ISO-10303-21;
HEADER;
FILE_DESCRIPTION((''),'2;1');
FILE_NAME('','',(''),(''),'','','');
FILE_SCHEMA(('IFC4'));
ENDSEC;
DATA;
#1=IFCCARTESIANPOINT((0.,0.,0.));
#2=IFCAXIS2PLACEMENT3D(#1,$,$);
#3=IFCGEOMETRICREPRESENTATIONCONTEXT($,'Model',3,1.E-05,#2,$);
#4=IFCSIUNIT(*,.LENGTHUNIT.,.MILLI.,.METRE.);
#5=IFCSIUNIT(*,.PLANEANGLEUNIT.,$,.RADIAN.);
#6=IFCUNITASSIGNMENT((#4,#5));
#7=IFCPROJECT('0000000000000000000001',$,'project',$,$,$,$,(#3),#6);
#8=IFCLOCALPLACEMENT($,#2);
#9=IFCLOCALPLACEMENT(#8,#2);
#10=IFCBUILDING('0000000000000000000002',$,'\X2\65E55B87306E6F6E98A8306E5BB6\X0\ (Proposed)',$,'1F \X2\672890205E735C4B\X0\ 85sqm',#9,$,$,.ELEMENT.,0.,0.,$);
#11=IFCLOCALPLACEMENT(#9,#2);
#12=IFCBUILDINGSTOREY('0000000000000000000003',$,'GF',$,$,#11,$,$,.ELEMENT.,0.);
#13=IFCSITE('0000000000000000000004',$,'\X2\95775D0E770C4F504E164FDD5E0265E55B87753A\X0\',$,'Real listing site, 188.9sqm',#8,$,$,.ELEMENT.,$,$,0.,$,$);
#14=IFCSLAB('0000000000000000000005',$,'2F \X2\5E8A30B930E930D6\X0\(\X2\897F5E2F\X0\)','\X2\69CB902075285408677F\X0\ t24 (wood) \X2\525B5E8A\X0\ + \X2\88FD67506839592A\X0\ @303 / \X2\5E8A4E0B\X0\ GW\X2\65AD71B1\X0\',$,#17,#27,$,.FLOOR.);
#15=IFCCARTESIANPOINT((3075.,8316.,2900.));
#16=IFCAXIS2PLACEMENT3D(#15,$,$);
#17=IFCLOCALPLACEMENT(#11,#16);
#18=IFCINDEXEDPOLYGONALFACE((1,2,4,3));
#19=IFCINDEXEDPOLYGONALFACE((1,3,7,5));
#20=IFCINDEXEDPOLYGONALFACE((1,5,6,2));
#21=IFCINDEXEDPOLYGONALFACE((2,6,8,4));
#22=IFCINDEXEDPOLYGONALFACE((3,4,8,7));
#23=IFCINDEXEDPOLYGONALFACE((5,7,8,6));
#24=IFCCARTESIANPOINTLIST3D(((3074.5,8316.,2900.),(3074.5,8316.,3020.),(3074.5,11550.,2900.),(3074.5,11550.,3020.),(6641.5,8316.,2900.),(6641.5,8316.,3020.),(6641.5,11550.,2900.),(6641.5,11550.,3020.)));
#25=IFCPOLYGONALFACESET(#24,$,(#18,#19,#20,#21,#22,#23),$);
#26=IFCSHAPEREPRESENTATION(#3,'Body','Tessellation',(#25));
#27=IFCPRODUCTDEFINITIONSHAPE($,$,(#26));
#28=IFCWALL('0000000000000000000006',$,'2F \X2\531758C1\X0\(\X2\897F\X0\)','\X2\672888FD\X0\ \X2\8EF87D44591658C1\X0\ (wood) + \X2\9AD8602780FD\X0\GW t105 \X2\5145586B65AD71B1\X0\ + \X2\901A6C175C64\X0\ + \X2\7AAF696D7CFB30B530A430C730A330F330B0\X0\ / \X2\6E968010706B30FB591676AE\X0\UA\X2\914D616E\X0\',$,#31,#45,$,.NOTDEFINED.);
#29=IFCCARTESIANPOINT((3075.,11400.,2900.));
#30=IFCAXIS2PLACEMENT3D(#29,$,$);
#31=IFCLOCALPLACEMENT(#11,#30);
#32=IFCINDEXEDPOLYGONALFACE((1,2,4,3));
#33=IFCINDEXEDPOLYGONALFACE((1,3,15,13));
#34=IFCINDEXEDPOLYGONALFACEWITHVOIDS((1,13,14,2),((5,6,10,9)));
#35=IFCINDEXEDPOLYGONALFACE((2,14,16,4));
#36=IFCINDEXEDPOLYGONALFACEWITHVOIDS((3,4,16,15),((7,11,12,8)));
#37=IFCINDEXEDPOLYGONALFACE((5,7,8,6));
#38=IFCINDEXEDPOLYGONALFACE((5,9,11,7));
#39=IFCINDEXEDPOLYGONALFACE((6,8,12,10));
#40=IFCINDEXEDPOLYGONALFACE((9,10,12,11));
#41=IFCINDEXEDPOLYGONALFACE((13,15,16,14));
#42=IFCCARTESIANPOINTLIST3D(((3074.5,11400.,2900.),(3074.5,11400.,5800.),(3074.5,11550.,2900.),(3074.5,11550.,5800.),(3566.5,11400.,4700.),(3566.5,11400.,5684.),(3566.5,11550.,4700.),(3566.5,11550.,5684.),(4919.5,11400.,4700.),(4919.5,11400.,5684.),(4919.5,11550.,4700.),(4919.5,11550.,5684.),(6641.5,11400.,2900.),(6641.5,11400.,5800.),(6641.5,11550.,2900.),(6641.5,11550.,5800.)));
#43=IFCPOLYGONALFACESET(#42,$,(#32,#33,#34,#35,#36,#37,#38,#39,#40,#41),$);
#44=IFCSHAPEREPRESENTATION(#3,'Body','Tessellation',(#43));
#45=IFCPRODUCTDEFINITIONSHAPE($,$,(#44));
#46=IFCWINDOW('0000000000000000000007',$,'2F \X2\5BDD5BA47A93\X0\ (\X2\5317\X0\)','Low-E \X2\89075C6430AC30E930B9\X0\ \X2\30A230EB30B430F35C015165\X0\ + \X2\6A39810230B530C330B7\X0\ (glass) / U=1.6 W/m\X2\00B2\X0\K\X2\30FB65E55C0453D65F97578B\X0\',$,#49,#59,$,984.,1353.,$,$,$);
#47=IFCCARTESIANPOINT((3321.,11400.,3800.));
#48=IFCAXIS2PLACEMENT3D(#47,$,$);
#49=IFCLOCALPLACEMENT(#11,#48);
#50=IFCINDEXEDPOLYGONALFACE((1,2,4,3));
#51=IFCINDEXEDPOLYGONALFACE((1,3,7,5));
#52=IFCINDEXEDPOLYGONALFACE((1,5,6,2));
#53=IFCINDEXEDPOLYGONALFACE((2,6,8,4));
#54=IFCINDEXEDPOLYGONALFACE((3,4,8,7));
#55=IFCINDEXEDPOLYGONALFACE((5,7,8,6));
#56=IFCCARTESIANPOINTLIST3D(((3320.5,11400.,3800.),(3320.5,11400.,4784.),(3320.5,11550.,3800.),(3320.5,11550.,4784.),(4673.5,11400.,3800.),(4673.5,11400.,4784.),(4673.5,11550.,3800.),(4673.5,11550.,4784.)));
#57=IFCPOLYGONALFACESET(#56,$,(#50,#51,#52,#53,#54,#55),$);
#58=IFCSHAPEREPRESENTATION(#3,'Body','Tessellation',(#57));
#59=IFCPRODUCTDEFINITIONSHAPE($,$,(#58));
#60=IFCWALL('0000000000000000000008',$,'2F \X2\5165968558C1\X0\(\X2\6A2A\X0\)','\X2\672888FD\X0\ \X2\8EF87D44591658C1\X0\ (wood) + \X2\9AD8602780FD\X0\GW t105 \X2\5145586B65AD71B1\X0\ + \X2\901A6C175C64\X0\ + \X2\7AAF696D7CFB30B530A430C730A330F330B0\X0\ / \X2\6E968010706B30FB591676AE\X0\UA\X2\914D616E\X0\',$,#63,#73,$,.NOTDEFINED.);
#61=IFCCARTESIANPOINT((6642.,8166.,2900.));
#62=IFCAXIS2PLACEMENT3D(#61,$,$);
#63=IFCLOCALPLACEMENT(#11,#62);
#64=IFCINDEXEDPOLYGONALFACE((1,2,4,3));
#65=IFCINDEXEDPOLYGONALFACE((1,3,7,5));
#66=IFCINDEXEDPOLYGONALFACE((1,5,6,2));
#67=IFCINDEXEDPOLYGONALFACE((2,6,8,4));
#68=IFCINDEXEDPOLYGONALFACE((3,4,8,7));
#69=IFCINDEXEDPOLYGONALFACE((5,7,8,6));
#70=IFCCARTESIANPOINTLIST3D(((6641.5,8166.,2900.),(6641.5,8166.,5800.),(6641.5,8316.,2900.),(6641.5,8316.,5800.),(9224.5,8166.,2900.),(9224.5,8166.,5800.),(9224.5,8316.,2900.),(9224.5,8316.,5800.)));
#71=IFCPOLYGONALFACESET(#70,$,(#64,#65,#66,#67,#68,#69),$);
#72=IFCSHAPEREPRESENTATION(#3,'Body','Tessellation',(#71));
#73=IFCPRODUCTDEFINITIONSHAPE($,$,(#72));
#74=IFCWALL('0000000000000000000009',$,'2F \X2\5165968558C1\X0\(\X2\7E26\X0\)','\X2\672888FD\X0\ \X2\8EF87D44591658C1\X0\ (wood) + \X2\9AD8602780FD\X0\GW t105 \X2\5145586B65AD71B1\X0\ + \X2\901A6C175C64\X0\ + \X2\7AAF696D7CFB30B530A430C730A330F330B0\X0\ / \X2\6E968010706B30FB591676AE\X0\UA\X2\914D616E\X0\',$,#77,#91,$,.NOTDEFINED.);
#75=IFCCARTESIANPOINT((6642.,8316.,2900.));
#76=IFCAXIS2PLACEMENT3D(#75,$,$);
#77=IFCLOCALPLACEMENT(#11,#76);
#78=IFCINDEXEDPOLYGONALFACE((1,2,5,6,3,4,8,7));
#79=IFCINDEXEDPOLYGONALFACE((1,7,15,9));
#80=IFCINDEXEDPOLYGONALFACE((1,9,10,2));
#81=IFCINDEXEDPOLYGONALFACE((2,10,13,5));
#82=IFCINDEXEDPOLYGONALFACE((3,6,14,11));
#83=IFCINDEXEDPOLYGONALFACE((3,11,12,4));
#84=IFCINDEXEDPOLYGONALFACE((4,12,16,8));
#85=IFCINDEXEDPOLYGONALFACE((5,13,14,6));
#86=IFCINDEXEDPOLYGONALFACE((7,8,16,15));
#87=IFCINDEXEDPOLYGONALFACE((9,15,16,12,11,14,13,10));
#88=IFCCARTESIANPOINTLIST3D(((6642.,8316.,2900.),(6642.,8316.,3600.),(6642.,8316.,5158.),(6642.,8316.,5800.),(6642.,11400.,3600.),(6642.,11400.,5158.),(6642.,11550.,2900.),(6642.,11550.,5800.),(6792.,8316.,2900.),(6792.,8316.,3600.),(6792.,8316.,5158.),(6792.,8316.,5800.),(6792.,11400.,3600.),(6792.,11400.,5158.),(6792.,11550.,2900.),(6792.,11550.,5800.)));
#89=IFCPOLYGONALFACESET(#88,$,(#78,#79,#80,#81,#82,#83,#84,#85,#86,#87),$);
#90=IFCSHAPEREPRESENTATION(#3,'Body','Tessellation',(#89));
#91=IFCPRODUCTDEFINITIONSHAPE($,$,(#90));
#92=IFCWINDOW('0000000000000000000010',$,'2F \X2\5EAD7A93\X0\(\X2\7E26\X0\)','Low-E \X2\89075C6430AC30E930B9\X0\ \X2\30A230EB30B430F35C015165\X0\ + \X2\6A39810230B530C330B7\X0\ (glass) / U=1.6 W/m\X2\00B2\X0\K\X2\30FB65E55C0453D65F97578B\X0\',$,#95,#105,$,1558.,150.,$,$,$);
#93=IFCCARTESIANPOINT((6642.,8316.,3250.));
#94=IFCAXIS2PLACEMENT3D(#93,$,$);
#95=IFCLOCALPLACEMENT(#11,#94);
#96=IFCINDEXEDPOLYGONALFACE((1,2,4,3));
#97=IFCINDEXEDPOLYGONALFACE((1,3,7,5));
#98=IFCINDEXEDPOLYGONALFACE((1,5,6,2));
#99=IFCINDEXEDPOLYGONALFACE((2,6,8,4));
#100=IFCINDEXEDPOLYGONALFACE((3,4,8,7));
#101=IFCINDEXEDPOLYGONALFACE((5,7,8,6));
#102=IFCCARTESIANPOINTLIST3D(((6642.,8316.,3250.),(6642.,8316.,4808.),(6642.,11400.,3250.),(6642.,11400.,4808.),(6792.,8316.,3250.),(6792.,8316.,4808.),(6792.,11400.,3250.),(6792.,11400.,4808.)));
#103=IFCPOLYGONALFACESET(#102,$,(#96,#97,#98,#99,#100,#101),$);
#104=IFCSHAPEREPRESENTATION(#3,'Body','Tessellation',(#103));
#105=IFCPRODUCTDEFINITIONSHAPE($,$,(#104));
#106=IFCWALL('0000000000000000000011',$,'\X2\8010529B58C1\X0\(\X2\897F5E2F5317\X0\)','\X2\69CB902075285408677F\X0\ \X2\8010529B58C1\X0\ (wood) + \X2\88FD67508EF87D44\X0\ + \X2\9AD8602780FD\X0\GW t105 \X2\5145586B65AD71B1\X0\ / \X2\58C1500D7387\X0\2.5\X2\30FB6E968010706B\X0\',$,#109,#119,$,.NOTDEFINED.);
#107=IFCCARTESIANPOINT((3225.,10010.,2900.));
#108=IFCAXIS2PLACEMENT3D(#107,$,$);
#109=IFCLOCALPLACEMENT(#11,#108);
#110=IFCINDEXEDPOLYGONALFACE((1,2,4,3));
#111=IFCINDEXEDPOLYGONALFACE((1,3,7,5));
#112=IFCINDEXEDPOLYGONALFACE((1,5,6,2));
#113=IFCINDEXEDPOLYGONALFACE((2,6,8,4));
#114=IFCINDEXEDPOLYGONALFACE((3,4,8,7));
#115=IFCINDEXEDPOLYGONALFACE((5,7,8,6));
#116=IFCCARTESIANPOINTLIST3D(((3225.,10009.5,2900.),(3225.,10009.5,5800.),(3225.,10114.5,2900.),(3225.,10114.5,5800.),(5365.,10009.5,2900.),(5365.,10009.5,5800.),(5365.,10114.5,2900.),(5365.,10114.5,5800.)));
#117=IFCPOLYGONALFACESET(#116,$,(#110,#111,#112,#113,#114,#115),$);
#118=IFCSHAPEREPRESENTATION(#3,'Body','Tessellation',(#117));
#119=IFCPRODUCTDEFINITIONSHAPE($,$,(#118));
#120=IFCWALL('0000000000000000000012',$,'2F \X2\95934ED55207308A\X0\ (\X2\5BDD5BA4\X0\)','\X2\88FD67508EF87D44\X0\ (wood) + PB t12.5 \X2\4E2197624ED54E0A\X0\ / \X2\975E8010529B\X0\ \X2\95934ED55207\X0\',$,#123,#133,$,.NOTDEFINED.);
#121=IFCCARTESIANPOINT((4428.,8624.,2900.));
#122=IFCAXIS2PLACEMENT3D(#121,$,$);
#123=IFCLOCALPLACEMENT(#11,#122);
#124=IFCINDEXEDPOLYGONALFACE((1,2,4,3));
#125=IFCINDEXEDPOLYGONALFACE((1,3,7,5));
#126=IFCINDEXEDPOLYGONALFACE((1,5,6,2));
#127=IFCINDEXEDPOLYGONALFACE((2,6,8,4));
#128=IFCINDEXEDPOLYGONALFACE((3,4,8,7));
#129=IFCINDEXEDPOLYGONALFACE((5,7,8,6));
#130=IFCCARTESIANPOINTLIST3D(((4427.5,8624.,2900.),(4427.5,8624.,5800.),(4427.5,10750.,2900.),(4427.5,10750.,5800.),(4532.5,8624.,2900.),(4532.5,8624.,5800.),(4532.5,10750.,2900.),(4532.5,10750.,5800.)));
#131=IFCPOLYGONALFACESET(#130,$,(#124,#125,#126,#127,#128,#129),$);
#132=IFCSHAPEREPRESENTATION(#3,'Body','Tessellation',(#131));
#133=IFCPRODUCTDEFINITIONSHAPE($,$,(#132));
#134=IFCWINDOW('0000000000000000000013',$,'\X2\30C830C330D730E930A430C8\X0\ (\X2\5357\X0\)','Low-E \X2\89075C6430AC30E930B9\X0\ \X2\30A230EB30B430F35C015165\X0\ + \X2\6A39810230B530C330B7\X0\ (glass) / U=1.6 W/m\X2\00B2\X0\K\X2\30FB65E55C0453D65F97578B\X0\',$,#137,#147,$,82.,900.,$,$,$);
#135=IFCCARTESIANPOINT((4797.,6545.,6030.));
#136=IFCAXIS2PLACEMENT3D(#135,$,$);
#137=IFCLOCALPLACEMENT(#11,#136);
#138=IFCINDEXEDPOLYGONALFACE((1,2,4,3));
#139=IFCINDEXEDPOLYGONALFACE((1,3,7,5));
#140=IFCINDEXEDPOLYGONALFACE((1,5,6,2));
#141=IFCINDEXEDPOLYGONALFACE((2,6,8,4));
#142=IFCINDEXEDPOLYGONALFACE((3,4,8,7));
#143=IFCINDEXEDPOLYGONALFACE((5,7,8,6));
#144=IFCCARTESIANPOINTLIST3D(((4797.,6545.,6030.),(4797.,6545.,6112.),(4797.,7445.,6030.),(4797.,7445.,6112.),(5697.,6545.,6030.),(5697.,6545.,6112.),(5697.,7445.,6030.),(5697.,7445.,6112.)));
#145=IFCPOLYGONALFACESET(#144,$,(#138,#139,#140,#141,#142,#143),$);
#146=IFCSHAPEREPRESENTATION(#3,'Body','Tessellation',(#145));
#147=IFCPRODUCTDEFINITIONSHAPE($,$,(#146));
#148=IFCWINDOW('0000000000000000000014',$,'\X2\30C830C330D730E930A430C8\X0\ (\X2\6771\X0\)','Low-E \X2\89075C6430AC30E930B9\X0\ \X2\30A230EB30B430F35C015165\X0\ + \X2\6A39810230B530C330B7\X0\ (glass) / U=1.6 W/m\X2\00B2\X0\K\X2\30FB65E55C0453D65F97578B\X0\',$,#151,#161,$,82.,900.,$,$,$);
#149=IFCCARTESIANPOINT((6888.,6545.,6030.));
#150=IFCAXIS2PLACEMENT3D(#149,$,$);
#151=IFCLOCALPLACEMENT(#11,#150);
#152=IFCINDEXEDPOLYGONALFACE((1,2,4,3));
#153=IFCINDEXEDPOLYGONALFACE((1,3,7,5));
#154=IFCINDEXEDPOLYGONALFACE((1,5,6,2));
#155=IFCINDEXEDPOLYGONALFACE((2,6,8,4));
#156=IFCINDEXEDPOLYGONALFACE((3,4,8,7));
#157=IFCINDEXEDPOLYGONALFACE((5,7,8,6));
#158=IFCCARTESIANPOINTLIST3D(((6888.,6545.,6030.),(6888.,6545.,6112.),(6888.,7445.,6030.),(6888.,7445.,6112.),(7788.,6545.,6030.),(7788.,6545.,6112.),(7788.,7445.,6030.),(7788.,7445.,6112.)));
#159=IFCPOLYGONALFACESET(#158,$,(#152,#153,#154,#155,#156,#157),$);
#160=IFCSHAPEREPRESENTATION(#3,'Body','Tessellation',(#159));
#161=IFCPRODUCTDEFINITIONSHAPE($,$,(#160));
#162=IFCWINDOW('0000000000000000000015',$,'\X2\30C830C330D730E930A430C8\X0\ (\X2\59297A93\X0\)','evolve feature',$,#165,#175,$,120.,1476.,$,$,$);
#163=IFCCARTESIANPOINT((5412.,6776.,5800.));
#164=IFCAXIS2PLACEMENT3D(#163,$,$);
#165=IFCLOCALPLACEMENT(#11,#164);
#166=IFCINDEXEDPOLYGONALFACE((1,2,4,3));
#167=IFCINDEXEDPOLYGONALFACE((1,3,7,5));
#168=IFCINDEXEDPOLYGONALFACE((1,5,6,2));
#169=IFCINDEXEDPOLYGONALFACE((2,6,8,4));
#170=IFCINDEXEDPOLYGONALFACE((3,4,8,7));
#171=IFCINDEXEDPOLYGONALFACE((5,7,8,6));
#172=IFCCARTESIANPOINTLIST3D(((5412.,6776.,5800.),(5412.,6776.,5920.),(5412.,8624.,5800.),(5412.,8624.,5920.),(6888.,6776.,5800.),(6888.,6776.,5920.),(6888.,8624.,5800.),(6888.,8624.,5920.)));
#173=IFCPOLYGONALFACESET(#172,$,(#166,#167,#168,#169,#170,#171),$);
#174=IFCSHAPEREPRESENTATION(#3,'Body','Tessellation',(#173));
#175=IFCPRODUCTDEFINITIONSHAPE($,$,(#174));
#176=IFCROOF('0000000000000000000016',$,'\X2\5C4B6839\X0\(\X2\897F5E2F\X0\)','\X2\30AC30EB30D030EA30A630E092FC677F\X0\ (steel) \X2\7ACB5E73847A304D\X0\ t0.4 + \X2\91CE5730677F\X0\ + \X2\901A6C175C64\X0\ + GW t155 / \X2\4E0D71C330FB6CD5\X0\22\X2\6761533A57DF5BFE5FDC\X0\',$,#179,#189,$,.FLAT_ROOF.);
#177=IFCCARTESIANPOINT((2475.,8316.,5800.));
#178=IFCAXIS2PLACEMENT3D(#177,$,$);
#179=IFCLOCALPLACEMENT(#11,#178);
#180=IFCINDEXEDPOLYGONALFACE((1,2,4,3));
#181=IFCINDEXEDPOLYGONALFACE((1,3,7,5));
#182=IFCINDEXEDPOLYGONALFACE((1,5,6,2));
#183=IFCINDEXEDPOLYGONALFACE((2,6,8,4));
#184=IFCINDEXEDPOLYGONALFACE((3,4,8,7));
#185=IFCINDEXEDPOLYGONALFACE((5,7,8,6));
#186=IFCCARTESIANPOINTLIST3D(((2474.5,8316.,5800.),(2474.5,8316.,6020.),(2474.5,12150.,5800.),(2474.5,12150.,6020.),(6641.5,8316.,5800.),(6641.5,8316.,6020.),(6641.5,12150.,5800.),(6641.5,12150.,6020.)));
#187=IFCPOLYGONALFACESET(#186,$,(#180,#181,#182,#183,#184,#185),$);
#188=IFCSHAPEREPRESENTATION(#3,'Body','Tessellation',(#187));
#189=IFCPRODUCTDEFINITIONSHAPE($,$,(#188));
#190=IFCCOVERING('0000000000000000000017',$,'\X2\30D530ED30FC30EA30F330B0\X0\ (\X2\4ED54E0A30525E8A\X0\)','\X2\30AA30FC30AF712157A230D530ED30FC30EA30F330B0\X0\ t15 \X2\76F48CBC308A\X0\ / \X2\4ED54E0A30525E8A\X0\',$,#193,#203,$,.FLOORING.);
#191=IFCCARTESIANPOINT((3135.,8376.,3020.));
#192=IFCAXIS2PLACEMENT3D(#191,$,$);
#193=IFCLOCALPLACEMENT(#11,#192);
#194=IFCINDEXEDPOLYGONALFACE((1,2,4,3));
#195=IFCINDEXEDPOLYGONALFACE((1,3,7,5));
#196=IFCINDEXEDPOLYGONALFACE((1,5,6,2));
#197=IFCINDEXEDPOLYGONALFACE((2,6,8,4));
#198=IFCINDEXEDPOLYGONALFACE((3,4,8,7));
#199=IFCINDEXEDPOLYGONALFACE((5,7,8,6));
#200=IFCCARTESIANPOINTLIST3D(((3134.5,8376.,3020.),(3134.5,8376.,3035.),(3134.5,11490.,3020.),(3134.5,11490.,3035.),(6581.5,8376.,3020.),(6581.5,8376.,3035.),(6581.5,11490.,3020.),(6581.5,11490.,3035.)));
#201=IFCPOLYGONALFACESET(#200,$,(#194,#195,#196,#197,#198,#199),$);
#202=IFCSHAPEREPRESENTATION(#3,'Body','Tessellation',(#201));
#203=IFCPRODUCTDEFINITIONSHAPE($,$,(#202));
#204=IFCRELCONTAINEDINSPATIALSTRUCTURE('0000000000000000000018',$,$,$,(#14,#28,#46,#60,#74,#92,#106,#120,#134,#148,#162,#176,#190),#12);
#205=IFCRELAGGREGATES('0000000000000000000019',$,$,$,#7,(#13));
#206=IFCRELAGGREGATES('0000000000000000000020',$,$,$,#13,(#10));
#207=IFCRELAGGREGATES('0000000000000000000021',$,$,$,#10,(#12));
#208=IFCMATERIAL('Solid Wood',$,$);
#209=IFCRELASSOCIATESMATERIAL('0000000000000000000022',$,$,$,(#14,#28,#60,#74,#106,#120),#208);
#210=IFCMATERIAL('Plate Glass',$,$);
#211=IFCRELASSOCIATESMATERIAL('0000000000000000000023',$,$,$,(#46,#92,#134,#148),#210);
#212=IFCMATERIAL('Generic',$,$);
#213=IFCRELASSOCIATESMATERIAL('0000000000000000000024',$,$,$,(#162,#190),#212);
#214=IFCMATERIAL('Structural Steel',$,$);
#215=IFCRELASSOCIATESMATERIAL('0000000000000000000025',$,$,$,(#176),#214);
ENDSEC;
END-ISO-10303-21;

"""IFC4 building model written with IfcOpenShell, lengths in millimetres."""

from ifc_helpers import new_model, si_unit, frame, frame_2d, origin, place, context, project, spatial, rectangle, extrude, material, element, fill, save


model = new_model("IFC4")

# Units and contexts
model_context = context("Model", 3, precision=1e-05, world=origin())
ifc_project = project(units=[si_unit("LENGTHUNIT", "METRE", prefix="MILLI"), si_unit("PLANEANGLEUNIT", "RADIAN")], contexts=[model_context])

# Site, building, storey
site_placement = place(None, origin())
site = spatial("IfcSite", under=ifc_project, at=site_placement, Name="長崎県佐世保市日宇町", ObjectType="Real listing site, 188.9sqm", CompositionType="ELEMENT", RefElevation=0.0)
building_placement = place(site_placement, origin())
building = spatial("IfcBuilding", under=site, at=building_placement, Name="日宇の潮風の家 (Proposed)", ObjectType="1F 木造平屋 85sqm", CompositionType="ELEMENT", ElevationOfRefHeight=0.0, ElevationOfTerrain=0.0)
storey_placement = place(building_placement, origin())
storey = spatial("IfcBuildingStorey", under=building, at=storey_placement, Name="GF", CompositionType="ELEMENT", Elevation=0.0)

# Slab
ifc_material_1 = material(Name="Solid Wood")
slab_placement = place(storey_placement, frame((3075.0, 8316.0, 2900.0)))
element("IfcSlab", 1, at=slab_placement, inside=storey, material=ifc_material_1, Name="2F 床スラブ(西帯)", Description="構造用合板 t24 (wood) 剛床 + 製材根太 @303 / 床下 GW断熱", PredefinedType="FLOOR", context=model_context, shape_type="SweptSolid", body=[
    extrude(rectangle(XDim=3567.0, YDim=3234.0, at=frame_2d((1783.0, 1617.0))), frame((3075.0, 8316.0, 2900.0)), (0.0, 0.0, 1.0), 120.0),
])

# Wall, opening, window
wall_1_placement = place(storey_placement, frame((3075.0, 11400.0, 2900.0)))
wall_1 = element("IfcWall", 2, at=wall_1_placement, inside=storey, material=ifc_material_1, Name="2F 北壁(西)", Description="木製 軸組外壁 (wood) + 高性能GW t105 充填断熱 + 通気層 + 窯業系サイディング / 準耐火・外皮UA配慮", PredefinedType="NOTDEFINED", context=model_context, shape_type="SweptSolid", body=[
    extrude(rectangle(XDim=3567.0, YDim=150.0, at=frame_2d((1783.0, 75.0))), frame((3075.0, 11400.0, 2900.0)), (0.0, 0.0, 1.0), 2900.0),
])
opening_1_placement = place(storey_placement, frame((3321.0, 11400.0, 3800.0)))
opening_1 = element("IfcOpeningElement", 3, at=opening_1_placement, cuts=wall_1, PredefinedType="NOTDEFINED", context=model_context, shape_type="SweptSolid", body=[
    extrude(rectangle(XDim=1353.0, YDim=150.0, at=frame_2d((676.0, 75.0))), frame((3321.0, 11400.0, 3800.0)), (0.0, 0.0, 1.0), 984.0),
])
ifc_material_2 = material(Name="Plate Glass")
window_1_placement = place(storey_placement, frame((3321.0, 11400.0, 3800.0)))
window_1 = element("IfcWindow", 4, at=window_1_placement, inside=storey, material=ifc_material_2, Name="2F 寝室窓 (北)", Description="Low-E 複層ガラス アルゴン封入 + 樹脂サッシ (glass) / U=1.6 W/m²K・日射取得型", OverallHeight=984.0, OverallWidth=1353.0, context=model_context, shape_type="SweptSolid", body=[
    extrude(rectangle(XDim=1353.0, YDim=150.0, at=frame_2d((676.0, 75.0))), frame((3321.0, 11400.0, 3800.0)), (0.0, 0.0, 1.0), 984.0),
])
fill(opening_1, window_1)

# Wall
wall_2_placement = place(storey_placement, frame((6642.0, 8166.0, 2900.0)))
element("IfcWall", 5, at=wall_2_placement, inside=storey, material=ifc_material_1, Name="2F 入隅壁(横)", Description="木製 軸組外壁 (wood) + 高性能GW t105 充填断熱 + 通気層 + 窯業系サイディング / 準耐火・外皮UA配慮", PredefinedType="NOTDEFINED", context=model_context, shape_type="SweptSolid", body=[
    extrude(rectangle(XDim=2583.0, YDim=150.0, at=frame_2d((1291.0, 75.0))), frame((6642.0, 8166.0, 2900.0)), (0.0, 0.0, 1.0), 2900.0),
])

# Wall, opening, window
wall_3_placement = place(storey_placement, frame((6642.0, 8316.0, 2900.0)))
wall_3 = element("IfcWall", 6, at=wall_3_placement, inside=storey, material=ifc_material_1, Name="2F 入隅壁(縦)", Description="木製 軸組外壁 (wood) + 高性能GW t105 充填断熱 + 通気層 + 窯業系サイディング / 準耐火・外皮UA配慮", PredefinedType="NOTDEFINED", context=model_context, shape_type="SweptSolid", body=[
    extrude(rectangle(XDim=150.0, YDim=3234.0, at=frame_2d((75.0, 1617.0))), frame((6642.0, 8316.0, 2900.0)), (0.0, 0.0, 1.0), 2900.0),
])
opening_2_placement = place(storey_placement, frame((6642.0, 8316.0, 3250.0)))
opening_2 = element("IfcOpeningElement", 7, at=opening_2_placement, cuts=wall_3, PredefinedType="NOTDEFINED", context=model_context, shape_type="SweptSolid", body=[
    extrude(rectangle(XDim=150.0, YDim=3084.0, at=frame_2d((75.0, 1542.0))), frame((6642.0, 8316.0, 3250.0)), (0.0, 0.0, 1.0), 1558.0),
])
window_2_placement = place(storey_placement, frame((6642.0, 8316.0, 3250.0)))
window_2 = element("IfcWindow", 8, at=window_2_placement, inside=storey, material=ifc_material_2, Name="2F 庭窓(縦)", Description="Low-E 複層ガラス アルゴン封入 + 樹脂サッシ (glass) / U=1.6 W/m²K・日射取得型", OverallHeight=1558.0, OverallWidth=150.0, context=model_context, shape_type="SweptSolid", body=[
    extrude(rectangle(XDim=150.0, YDim=3084.0, at=frame_2d((75.0, 1542.0))), frame((6642.0, 8316.0, 3250.0)), (0.0, 0.0, 1.0), 1558.0),
])
fill(opening_2, window_2)

# Walls
wall_4_placement = place(storey_placement, frame((3225.0, 10010.0, 2900.0)))
element("IfcWall", 9, at=wall_4_placement, inside=storey, material=ifc_material_1, Name="耐力壁(西帯北)", Description="構造用合板 耐力壁 (wood) + 製材軸組 + 高性能GW t105 充填断熱 / 壁倍率2.5・準耐火", PredefinedType="NOTDEFINED", context=model_context, shape_type="SweptSolid", body=[
    extrude(rectangle(XDim=2140.0, YDim=105.0, at=frame_2d((1070.0, 52.0))), frame((3225.0, 10010.0, 2900.0)), (0.0, 0.0, 1.0), 2900.0),
])
wall_5_placement = place(storey_placement, frame((4428.0, 8624.0, 2900.0)))
element("IfcWall", 10, at=wall_5_placement, inside=storey, material=ifc_material_1, Name="2F 間仕切り (寝室)", Description="製材軸組 (wood) + PB t12.5 両面仕上 / 非耐力 間仕切", PredefinedType="NOTDEFINED", context=model_context, shape_type="SweptSolid", body=[
    extrude(rectangle(XDim=105.0, YDim=2126.0, at=frame_2d((52.0, 1063.0))), frame((4428.0, 8624.0, 2900.0)), (0.0, 0.0, 1.0), 2900.0),
])

# Windows
window_3_placement = place(storey_placement, frame((4797.0, 6545.0, 6030.0)))
element("IfcWindow", 11, at=window_3_placement, inside=storey, material=ifc_material_2, Name="トップライト (南)", Description="Low-E 複層ガラス アルゴン封入 + 樹脂サッシ (glass) / U=1.6 W/m²K・日射取得型", OverallHeight=82.0, OverallWidth=900.0, context=model_context, shape_type="SweptSolid", body=[
    extrude(rectangle(XDim=900.0, YDim=900.0, at=frame_2d((450.0, 450.0))), frame((4797.0, 6545.0, 6030.0)), (0.0, 0.0, 1.0), 82.0),
])
window_4_placement = place(storey_placement, frame((6888.0, 6545.0, 6030.0)))
element("IfcWindow", 12, at=window_4_placement, inside=storey, material=ifc_material_2, Name="トップライト (東)", Description="Low-E 複層ガラス アルゴン封入 + 樹脂サッシ (glass) / U=1.6 W/m²K・日射取得型", OverallHeight=82.0, OverallWidth=900.0, context=model_context, shape_type="SweptSolid", body=[
    extrude(rectangle(XDim=900.0, YDim=900.0, at=frame_2d((450.0, 450.0))), frame((6888.0, 6545.0, 6030.0)), (0.0, 0.0, 1.0), 82.0),
])
ifc_material_3 = material(Name="Generic")
window_5_placement = place(storey_placement, frame((5412.0, 6776.0, 5800.0)))
element("IfcWindow", 13, at=window_5_placement, inside=storey, material=ifc_material_3, Name="トップライト (天窓)", Description="evolve feature", OverallHeight=120.0, OverallWidth=1476.0, context=model_context, shape_type="SweptSolid", body=[
    extrude(rectangle(XDim=1476.0, YDim=1848.0, at=frame_2d((738.0, 924.0))), frame((5412.0, 6776.0, 5800.0)), (0.0, 0.0, 1.0), 120.0),
])

# Roof
ifc_material_4 = material(Name="Structural Steel")
for number, where, name in (
    (14, (2475.0, 8316.0, 5800.0), "屋根(西帯)"),
):
    element("IfcRoof", number, at=place(storey_placement, frame(where)), inside=storey, material=ifc_material_4, Name=name, Description="ガルバリウム鋼板 (steel) 立平葺き t0.4 + 野地板 + 通気層 + GW t155 / 不燃・法22条区域対応", PredefinedType="FLAT_ROOF", context=model_context, shape_type="SweptSolid", body=[
        extrude(rectangle(XDim=4167.0, YDim=3834.0, at=frame_2d((2083.0, 1917.0))), frame((2475.0, 8316.0, 5800.0)), (0.0, 0.0, 1.0), 220.0),
    ])

# Covering
covering_placement = place(storey_placement, frame((3135.0, 8376.0, 3020.0)))
element("IfcCovering", 15, at=covering_placement, inside=storey, material=ifc_material_3, Name="フローリング (仕上げ床)", Description="オーク無垢フローリング t15 直貼り / 仕上げ床", PredefinedType="FLOORING", context=model_context, shape_type="SweptSolid", body=[
    extrude(rectangle(XDim=3447.0, YDim=3114.0, at=frame_2d((1723.0, 1557.0))), frame((3135.0, 8376.0, 3020.0)), (0.0, 0.0, 1.0), 15.0),
])

save(model, "model.ifc")
